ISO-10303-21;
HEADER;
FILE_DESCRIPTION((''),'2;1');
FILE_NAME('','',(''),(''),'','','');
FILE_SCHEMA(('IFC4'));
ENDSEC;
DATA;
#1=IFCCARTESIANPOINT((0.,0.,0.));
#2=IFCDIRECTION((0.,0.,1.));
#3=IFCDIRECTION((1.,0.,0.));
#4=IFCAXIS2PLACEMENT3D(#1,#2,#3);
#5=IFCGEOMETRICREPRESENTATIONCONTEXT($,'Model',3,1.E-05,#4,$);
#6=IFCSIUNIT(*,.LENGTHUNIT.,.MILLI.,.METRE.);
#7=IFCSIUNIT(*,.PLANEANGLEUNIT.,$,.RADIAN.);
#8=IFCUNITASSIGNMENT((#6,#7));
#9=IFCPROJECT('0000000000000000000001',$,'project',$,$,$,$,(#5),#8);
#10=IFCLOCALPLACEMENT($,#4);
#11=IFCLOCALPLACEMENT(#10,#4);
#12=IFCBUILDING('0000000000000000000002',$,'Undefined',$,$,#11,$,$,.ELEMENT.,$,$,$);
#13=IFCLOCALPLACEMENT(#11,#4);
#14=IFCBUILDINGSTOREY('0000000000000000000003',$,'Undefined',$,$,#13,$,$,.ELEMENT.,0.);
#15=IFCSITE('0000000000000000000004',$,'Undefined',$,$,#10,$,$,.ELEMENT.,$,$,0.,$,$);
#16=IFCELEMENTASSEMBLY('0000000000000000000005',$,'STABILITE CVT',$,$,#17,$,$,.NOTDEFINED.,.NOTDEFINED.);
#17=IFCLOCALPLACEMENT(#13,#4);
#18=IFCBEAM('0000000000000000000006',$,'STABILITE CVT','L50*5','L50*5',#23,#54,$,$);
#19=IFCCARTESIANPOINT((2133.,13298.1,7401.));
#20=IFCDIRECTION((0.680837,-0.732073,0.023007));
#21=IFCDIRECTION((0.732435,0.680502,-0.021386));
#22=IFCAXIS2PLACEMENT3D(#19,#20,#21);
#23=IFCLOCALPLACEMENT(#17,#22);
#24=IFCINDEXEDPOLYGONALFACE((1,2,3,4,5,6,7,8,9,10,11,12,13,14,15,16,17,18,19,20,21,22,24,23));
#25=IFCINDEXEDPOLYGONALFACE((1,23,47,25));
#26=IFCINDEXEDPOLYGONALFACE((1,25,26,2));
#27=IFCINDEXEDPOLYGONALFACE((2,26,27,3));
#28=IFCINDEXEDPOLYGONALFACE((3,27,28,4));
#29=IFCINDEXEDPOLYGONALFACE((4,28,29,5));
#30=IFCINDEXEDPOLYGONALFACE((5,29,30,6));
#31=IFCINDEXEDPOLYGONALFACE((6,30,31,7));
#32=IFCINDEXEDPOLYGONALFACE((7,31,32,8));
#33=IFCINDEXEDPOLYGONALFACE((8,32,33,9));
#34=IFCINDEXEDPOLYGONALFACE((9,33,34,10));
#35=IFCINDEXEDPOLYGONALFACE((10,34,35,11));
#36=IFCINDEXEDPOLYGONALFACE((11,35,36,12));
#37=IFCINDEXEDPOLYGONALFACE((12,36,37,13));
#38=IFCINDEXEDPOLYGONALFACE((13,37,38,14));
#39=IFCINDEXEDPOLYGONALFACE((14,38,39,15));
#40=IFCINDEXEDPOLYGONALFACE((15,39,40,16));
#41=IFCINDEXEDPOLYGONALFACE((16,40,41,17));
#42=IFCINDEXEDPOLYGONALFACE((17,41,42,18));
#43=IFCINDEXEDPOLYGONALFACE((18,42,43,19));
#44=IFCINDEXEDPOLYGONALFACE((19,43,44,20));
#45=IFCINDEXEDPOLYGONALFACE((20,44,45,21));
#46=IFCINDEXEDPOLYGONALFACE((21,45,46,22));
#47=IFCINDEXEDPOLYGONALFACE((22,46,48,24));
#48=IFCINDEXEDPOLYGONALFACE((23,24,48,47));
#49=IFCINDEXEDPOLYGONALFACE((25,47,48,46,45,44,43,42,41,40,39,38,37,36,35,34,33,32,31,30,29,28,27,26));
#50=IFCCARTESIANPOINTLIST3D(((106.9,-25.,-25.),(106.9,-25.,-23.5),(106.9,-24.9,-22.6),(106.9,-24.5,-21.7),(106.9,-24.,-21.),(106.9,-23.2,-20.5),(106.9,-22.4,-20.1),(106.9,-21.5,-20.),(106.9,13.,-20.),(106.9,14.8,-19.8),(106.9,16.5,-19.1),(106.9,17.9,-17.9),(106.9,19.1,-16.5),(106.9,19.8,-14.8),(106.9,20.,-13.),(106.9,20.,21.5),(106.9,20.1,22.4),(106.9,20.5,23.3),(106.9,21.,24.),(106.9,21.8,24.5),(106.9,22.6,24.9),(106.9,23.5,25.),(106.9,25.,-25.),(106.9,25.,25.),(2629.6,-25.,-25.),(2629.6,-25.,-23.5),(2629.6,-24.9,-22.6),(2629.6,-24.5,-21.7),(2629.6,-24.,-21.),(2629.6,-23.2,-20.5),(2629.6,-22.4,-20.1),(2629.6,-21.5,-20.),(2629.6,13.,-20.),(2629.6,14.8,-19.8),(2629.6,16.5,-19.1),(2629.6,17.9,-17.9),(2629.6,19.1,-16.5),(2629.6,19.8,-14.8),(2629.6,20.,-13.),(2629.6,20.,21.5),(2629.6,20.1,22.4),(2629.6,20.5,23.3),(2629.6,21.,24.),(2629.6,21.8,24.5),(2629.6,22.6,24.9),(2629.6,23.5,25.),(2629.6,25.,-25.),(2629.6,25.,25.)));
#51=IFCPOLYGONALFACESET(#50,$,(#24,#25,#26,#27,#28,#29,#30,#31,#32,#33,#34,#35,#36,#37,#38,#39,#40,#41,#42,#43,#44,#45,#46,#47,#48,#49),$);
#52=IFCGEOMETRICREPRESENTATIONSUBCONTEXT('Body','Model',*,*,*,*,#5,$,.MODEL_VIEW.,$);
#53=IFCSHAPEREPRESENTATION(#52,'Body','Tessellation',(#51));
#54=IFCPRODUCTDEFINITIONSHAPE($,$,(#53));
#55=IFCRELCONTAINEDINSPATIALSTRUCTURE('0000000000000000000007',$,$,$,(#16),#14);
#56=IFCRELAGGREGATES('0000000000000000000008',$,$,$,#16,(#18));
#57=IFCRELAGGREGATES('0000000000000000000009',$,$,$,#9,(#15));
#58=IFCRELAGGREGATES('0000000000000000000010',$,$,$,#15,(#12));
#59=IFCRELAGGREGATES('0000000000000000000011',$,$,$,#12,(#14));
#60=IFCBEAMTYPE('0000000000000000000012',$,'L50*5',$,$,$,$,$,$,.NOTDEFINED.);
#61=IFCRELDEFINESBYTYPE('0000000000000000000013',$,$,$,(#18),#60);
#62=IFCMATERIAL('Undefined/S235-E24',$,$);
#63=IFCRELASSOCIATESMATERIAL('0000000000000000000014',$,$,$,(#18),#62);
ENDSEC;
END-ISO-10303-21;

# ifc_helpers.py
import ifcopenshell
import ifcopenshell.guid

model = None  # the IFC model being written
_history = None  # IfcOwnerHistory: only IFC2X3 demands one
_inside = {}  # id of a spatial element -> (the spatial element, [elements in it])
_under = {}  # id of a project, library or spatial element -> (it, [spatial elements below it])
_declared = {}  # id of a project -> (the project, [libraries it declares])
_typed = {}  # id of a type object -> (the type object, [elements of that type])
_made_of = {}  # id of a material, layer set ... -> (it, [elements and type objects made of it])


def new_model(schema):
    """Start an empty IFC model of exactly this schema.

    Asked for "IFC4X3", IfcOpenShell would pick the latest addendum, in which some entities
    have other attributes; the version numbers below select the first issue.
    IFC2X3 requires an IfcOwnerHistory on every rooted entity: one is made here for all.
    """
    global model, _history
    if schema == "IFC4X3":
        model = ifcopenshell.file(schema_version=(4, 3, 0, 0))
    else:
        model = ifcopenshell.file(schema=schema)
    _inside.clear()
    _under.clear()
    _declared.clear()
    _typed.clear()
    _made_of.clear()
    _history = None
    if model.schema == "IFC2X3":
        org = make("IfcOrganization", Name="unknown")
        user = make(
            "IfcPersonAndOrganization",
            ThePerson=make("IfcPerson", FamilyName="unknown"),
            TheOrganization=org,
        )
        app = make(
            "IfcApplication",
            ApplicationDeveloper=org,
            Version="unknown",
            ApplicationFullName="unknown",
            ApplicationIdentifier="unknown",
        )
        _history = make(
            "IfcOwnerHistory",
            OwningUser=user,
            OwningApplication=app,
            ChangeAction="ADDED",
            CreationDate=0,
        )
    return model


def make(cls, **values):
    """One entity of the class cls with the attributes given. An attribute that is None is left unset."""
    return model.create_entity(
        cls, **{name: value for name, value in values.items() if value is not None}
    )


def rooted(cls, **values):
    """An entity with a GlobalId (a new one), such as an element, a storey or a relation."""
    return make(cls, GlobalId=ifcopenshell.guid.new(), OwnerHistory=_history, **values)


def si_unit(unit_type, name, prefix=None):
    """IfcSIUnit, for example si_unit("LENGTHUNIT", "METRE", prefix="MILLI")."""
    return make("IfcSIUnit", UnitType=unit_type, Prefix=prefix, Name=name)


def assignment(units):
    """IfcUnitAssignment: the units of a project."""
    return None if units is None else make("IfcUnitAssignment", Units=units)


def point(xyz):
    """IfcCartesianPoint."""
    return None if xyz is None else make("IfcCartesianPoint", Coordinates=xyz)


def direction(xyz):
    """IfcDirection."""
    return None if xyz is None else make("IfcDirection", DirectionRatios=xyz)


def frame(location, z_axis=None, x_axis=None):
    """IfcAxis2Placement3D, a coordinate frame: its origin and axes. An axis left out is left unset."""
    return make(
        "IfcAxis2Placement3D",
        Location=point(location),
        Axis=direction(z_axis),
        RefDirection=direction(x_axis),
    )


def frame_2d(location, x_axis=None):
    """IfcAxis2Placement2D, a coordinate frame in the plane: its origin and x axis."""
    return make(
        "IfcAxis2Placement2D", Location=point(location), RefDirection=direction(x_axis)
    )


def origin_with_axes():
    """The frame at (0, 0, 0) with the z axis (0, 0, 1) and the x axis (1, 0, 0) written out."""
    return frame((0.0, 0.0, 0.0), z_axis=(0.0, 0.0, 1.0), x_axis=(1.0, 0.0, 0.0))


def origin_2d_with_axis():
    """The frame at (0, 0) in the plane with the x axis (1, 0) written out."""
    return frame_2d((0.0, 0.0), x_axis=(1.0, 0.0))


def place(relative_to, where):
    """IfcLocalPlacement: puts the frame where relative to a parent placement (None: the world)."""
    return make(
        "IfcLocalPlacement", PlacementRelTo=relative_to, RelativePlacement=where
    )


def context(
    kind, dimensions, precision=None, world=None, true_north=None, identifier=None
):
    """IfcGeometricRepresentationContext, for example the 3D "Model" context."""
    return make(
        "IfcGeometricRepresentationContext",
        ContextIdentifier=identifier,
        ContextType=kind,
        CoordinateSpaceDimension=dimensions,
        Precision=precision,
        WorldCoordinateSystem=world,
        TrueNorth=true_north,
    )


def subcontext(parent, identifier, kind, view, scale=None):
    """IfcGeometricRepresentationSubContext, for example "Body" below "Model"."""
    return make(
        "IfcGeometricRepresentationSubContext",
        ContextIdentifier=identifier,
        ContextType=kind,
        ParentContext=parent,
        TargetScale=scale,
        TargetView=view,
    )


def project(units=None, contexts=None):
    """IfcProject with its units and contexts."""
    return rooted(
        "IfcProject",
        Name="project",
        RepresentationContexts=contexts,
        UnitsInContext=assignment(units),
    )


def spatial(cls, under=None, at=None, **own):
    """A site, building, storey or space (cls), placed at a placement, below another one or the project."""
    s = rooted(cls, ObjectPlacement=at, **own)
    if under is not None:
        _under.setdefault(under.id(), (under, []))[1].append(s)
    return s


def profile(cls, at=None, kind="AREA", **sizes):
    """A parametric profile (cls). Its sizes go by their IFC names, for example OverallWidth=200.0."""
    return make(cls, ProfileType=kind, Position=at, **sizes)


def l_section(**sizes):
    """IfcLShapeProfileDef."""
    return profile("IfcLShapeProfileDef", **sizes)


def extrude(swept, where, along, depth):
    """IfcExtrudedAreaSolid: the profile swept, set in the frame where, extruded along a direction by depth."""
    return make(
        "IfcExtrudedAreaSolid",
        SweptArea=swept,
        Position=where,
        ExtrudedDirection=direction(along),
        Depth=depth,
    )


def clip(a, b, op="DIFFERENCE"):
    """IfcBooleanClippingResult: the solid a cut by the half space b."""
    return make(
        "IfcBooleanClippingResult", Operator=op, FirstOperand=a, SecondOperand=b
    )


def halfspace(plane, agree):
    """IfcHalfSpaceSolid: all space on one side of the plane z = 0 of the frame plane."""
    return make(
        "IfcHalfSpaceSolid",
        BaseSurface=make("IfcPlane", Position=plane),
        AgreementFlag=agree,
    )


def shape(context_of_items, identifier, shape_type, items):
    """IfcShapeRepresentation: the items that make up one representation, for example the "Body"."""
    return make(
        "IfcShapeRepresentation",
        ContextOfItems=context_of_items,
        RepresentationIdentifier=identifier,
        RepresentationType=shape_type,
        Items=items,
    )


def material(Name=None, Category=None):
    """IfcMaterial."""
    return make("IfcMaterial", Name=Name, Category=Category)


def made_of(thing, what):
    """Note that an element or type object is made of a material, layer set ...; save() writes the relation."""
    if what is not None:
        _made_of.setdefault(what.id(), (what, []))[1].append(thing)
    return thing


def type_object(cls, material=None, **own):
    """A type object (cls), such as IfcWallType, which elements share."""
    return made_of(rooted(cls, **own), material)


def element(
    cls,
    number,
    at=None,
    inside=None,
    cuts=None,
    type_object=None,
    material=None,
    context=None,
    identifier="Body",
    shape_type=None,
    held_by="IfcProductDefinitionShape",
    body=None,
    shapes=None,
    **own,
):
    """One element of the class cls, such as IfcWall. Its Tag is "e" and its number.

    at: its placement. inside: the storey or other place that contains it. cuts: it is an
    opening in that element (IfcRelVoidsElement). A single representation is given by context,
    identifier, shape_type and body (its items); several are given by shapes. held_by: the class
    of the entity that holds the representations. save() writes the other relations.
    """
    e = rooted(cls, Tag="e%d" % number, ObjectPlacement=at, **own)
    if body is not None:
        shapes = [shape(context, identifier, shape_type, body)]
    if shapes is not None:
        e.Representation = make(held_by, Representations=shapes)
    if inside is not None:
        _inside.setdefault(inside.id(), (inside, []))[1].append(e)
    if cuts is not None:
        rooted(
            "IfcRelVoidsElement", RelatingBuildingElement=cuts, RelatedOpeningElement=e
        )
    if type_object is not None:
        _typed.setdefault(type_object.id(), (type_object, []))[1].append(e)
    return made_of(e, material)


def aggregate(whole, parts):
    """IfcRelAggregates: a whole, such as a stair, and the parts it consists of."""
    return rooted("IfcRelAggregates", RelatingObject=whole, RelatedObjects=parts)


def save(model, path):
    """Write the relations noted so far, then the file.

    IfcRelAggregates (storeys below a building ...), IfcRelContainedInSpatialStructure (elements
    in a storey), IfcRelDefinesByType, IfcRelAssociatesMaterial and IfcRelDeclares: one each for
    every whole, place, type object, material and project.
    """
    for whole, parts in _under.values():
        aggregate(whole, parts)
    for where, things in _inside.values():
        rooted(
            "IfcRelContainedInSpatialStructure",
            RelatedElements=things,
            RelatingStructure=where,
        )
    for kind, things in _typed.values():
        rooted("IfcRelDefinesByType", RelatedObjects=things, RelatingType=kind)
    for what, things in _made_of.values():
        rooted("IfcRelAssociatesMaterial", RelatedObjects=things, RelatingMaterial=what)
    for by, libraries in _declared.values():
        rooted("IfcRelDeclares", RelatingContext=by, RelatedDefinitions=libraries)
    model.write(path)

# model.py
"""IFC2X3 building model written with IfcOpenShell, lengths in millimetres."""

from ifc_helpers import new_model, si_unit, frame, origin_with_axes, origin_2d_with_axis, place, context, subcontext, project, spatial, l_section, extrude, clip, halfspace, material, type_object, element, aggregate, save


model = new_model("IFC2X3")

# Units and contexts
model_context = context("Model", 3, precision=1e-05, world=origin_with_axes())
body_context = subcontext(model_context, "Body", "Model", "MODEL_VIEW")
ifc_project = project(units=[si_unit("LENGTHUNIT", "METRE", prefix="MILLI"), si_unit("PLANEANGLEUNIT", "RADIAN")], contexts=[model_context])

# Site, building, storey
site_placement = place(None, origin_with_axes())
site = spatial("IfcSite", under=ifc_project, at=site_placement, Name="Undefined", CompositionType="ELEMENT", RefElevation=0.0)
building_placement = place(site_placement, origin_with_axes())
building = spatial("IfcBuilding", under=site, at=building_placement, Name="Undefined", CompositionType="ELEMENT")
storey_placement = place(building_placement, origin_with_axes())
storey = spatial("IfcBuildingStorey", under=building, at=storey_placement, Name="Undefined", CompositionType="ELEMENT", Elevation=0.0)

# Shared definitions
ifc_material_1 = material(Name="Undefined/S235-E24")

# Element assembly, beam
beam_type_1 = type_object("IfcBeamType", Name="L50*5", PredefinedType="NOTDEFINED")
assembly_1_placement = place(storey_placement, origin_with_axes())
assembly_1 = element("IfcElementAssembly", 1, at=assembly_1_placement, inside=storey, Name="STABILITE CVT", AssemblyPlace="NOTDEFINED", PredefinedType="NOTDEFINED")
beam_1_placement = place(assembly_1_placement, frame((2133.0, 13298.1, 7401.0), z_axis=(0.680837, -0.732073, 0.023007), x_axis=(0.732435, 0.680502, -0.021386)))
beam_1 = element("IfcBeam", 2, at=beam_1_placement, type_object=beam_type_1, material=ifc_material_1, Name="STABILITE CVT", Description="L50*5", ObjectType="L50*5", context=body_context, shape_type="Clipping", body=[
    clip(clip(extrude(l_section(Depth=50.0, Width=50.0, Thickness=5.0, FilletRadius=7.0, EdgeRadius=3.5, at=origin_2d_with_axis()), frame((2792.1, 0.0, 0.0), z_axis=(-1.0, 0.0, 0.0), x_axis=(0.0, -1.0, 0.0)), (0.0, 0.0, 1.0), 2736.7), halfspace(frame((2629.6, 25.0, 25.0), z_axis=(1.0, 0.0, -0.000001), x_axis=(-0.000001, 0.0, -1.0)), False)), halfspace(frame((106.9, 31.0, 25.0), z_axis=(1.0, 0.0, 0.0), x_axis=(0.0, 1.0, 0.0)), True)),
])
aggregate(assembly_1, [beam_1])

save(model, "model.ifc")
